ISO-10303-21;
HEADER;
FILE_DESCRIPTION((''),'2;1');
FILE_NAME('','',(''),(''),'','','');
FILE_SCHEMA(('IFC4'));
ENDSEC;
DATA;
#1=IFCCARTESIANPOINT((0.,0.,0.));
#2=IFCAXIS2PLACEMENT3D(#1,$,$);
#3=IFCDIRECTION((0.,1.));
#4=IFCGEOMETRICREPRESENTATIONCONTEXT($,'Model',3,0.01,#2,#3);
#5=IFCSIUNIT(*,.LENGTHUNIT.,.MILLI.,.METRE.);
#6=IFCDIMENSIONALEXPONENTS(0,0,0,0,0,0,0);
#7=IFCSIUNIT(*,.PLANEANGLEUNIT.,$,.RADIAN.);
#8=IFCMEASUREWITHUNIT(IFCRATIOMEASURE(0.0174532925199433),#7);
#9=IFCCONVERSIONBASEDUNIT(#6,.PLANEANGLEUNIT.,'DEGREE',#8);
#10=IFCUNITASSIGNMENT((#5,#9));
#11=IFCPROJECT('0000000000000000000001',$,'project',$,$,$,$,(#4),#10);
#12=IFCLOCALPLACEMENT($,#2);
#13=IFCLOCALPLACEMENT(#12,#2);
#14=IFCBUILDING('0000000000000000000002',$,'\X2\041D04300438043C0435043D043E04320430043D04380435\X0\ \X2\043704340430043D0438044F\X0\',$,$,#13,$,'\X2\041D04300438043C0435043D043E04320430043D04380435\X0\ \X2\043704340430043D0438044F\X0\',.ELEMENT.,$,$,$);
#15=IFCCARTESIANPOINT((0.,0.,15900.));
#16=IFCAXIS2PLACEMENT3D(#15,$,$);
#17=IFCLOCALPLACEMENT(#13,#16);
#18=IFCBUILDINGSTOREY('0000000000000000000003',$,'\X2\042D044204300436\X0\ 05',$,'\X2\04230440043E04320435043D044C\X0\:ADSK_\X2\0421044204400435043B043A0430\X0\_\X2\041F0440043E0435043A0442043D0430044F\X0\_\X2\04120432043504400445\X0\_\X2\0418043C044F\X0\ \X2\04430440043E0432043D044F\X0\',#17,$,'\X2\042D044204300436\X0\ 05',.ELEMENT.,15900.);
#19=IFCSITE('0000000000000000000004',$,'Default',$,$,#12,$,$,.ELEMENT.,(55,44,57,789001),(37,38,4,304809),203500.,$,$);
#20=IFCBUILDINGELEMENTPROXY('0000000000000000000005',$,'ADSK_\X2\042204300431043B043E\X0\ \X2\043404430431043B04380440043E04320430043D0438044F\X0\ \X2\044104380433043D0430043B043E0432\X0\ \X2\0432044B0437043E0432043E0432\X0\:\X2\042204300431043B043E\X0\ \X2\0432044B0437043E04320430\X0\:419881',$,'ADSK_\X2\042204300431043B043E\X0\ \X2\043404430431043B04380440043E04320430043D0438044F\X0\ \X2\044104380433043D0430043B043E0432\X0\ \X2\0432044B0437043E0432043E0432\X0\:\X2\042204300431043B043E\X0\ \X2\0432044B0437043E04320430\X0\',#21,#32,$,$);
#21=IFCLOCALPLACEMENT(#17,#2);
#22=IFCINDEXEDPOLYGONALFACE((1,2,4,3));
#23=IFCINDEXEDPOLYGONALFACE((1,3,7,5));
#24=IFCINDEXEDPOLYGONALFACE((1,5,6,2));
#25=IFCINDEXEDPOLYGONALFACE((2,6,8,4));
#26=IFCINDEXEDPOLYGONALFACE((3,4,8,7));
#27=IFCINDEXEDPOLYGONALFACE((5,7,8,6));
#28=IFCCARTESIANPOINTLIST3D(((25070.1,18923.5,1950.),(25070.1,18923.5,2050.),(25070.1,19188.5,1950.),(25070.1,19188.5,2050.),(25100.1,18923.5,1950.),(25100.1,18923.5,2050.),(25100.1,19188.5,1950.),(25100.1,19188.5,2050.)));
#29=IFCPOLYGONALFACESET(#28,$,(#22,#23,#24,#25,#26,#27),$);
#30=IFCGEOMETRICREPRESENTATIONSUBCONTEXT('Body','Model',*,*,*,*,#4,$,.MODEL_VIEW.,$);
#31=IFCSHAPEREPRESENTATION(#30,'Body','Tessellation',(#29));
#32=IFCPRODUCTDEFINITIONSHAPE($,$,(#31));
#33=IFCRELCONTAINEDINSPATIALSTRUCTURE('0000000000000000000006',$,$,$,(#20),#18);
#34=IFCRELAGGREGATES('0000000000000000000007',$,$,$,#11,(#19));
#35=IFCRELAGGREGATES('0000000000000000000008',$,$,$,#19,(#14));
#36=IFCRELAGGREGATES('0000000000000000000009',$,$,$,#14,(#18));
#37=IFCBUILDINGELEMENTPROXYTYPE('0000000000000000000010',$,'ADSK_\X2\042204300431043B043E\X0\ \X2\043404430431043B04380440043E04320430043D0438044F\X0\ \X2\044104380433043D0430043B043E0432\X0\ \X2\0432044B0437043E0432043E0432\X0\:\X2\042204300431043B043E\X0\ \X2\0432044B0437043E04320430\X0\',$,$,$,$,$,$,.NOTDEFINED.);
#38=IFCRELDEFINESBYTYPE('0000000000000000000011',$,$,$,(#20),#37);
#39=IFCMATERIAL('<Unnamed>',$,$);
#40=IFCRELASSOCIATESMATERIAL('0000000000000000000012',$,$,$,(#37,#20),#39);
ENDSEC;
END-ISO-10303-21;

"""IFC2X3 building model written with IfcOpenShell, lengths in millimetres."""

from ifc_helpers import new_model, entity, si_unit, converted_unit, direction, frame, origin, origin_2d_with_axis, place, context, subcontext, project, spatial, rectangle, extrude, source, transform, mapped, material, type_object, type_shapes, element, save


model = new_model("IFC2X3")

# Units and contexts
model_context = context("Model", 3, precision=0.01, world=origin(), true_north=direction((0.0, 1.0)))
body_context = subcontext(model_context, "Body", "Model", "MODEL_VIEW")
ifc_project = project(units=[si_unit("LENGTHUNIT", "METRE", prefix="MILLI"), converted_unit("PLANEANGLEUNIT", "DEGREE", entity("IfcRatioMeasure", 0.0174532925199433), si_unit("PLANEANGLEUNIT", "RADIAN"), dimensions=[0, 0, 0, 0, 0, 0, 0])], contexts=[model_context])

# Site, building, storey
site_placement = place(None, origin())
site = spatial("IfcSite", under=ifc_project, at=site_placement, Name="Default", CompositionType="ELEMENT", RefLatitude=(55, 44, 57, 789001), RefLongitude=(37, 38, 4, 304809), RefElevation=203500.0)
building_placement = place(site_placement, origin())
building = spatial("IfcBuilding", under=site, at=building_placement, Name="Наименование здания", LongName="Наименование здания", CompositionType="ELEMENT")
storey_placement = place(building_placement, frame((0.0, 0.0, 15900.0)))
storey = spatial("IfcBuildingStorey", under=building, at=storey_placement, Name="Этаж 05", ObjectType="Уровень:ADSK_Стрелка_Проектная_Вверх_Имя уровня", LongName="Этаж 05", CompositionType="ELEMENT", Elevation=15900.0)

# Building element proxy
ifc_material_1 = material(Name="<Unnamed>")
building_element_proxy_type_1 = type_object("IfcBuildingElementProxyType", Name="ADSK_Табло дублирования сигналов вызовов:Табло вызова", PredefinedType="NOTDEFINED", material=ifc_material_1)
shared_shape_1 = source(origin(), body_context, "Body", "SweptSolid", [
    extrude(rectangle(XDim=265.0, YDim=30.0, at=origin_2d_with_axis()), frame((132.5, 15.0, 0.0), z_axis=(0.0, 0.0, 1.0), x_axis=(-1.0, 0.0, 0.0)), (0.0, 0.0, 1.0), 100.0),
])
type_shapes(building_element_proxy_type_1, [shared_shape_1])
proxy_1_placement = place(storey_placement, frame((25100.1, 18923.5, 1950.0), z_axis=(0.0, 0.0, 1.0), x_axis=(0.0, 1.0, 0.0)))
element("IfcBuildingElementProxy", 1, at=proxy_1_placement, inside=storey, type_object=building_element_proxy_type_1, material=ifc_material_1, Name="ADSK_Табло дублирования сигналов вызовов:Табло вызова:419881", ObjectType="ADSK_Табло дублирования сигналов вызовов:Табло вызова", context=body_context, shape_type="MappedRepresentation", body=[
    mapped(shared_shape_1, transform((0.0, 0.0, 0.0), scale=1.0)),
])

save(model, "model.ifc")
